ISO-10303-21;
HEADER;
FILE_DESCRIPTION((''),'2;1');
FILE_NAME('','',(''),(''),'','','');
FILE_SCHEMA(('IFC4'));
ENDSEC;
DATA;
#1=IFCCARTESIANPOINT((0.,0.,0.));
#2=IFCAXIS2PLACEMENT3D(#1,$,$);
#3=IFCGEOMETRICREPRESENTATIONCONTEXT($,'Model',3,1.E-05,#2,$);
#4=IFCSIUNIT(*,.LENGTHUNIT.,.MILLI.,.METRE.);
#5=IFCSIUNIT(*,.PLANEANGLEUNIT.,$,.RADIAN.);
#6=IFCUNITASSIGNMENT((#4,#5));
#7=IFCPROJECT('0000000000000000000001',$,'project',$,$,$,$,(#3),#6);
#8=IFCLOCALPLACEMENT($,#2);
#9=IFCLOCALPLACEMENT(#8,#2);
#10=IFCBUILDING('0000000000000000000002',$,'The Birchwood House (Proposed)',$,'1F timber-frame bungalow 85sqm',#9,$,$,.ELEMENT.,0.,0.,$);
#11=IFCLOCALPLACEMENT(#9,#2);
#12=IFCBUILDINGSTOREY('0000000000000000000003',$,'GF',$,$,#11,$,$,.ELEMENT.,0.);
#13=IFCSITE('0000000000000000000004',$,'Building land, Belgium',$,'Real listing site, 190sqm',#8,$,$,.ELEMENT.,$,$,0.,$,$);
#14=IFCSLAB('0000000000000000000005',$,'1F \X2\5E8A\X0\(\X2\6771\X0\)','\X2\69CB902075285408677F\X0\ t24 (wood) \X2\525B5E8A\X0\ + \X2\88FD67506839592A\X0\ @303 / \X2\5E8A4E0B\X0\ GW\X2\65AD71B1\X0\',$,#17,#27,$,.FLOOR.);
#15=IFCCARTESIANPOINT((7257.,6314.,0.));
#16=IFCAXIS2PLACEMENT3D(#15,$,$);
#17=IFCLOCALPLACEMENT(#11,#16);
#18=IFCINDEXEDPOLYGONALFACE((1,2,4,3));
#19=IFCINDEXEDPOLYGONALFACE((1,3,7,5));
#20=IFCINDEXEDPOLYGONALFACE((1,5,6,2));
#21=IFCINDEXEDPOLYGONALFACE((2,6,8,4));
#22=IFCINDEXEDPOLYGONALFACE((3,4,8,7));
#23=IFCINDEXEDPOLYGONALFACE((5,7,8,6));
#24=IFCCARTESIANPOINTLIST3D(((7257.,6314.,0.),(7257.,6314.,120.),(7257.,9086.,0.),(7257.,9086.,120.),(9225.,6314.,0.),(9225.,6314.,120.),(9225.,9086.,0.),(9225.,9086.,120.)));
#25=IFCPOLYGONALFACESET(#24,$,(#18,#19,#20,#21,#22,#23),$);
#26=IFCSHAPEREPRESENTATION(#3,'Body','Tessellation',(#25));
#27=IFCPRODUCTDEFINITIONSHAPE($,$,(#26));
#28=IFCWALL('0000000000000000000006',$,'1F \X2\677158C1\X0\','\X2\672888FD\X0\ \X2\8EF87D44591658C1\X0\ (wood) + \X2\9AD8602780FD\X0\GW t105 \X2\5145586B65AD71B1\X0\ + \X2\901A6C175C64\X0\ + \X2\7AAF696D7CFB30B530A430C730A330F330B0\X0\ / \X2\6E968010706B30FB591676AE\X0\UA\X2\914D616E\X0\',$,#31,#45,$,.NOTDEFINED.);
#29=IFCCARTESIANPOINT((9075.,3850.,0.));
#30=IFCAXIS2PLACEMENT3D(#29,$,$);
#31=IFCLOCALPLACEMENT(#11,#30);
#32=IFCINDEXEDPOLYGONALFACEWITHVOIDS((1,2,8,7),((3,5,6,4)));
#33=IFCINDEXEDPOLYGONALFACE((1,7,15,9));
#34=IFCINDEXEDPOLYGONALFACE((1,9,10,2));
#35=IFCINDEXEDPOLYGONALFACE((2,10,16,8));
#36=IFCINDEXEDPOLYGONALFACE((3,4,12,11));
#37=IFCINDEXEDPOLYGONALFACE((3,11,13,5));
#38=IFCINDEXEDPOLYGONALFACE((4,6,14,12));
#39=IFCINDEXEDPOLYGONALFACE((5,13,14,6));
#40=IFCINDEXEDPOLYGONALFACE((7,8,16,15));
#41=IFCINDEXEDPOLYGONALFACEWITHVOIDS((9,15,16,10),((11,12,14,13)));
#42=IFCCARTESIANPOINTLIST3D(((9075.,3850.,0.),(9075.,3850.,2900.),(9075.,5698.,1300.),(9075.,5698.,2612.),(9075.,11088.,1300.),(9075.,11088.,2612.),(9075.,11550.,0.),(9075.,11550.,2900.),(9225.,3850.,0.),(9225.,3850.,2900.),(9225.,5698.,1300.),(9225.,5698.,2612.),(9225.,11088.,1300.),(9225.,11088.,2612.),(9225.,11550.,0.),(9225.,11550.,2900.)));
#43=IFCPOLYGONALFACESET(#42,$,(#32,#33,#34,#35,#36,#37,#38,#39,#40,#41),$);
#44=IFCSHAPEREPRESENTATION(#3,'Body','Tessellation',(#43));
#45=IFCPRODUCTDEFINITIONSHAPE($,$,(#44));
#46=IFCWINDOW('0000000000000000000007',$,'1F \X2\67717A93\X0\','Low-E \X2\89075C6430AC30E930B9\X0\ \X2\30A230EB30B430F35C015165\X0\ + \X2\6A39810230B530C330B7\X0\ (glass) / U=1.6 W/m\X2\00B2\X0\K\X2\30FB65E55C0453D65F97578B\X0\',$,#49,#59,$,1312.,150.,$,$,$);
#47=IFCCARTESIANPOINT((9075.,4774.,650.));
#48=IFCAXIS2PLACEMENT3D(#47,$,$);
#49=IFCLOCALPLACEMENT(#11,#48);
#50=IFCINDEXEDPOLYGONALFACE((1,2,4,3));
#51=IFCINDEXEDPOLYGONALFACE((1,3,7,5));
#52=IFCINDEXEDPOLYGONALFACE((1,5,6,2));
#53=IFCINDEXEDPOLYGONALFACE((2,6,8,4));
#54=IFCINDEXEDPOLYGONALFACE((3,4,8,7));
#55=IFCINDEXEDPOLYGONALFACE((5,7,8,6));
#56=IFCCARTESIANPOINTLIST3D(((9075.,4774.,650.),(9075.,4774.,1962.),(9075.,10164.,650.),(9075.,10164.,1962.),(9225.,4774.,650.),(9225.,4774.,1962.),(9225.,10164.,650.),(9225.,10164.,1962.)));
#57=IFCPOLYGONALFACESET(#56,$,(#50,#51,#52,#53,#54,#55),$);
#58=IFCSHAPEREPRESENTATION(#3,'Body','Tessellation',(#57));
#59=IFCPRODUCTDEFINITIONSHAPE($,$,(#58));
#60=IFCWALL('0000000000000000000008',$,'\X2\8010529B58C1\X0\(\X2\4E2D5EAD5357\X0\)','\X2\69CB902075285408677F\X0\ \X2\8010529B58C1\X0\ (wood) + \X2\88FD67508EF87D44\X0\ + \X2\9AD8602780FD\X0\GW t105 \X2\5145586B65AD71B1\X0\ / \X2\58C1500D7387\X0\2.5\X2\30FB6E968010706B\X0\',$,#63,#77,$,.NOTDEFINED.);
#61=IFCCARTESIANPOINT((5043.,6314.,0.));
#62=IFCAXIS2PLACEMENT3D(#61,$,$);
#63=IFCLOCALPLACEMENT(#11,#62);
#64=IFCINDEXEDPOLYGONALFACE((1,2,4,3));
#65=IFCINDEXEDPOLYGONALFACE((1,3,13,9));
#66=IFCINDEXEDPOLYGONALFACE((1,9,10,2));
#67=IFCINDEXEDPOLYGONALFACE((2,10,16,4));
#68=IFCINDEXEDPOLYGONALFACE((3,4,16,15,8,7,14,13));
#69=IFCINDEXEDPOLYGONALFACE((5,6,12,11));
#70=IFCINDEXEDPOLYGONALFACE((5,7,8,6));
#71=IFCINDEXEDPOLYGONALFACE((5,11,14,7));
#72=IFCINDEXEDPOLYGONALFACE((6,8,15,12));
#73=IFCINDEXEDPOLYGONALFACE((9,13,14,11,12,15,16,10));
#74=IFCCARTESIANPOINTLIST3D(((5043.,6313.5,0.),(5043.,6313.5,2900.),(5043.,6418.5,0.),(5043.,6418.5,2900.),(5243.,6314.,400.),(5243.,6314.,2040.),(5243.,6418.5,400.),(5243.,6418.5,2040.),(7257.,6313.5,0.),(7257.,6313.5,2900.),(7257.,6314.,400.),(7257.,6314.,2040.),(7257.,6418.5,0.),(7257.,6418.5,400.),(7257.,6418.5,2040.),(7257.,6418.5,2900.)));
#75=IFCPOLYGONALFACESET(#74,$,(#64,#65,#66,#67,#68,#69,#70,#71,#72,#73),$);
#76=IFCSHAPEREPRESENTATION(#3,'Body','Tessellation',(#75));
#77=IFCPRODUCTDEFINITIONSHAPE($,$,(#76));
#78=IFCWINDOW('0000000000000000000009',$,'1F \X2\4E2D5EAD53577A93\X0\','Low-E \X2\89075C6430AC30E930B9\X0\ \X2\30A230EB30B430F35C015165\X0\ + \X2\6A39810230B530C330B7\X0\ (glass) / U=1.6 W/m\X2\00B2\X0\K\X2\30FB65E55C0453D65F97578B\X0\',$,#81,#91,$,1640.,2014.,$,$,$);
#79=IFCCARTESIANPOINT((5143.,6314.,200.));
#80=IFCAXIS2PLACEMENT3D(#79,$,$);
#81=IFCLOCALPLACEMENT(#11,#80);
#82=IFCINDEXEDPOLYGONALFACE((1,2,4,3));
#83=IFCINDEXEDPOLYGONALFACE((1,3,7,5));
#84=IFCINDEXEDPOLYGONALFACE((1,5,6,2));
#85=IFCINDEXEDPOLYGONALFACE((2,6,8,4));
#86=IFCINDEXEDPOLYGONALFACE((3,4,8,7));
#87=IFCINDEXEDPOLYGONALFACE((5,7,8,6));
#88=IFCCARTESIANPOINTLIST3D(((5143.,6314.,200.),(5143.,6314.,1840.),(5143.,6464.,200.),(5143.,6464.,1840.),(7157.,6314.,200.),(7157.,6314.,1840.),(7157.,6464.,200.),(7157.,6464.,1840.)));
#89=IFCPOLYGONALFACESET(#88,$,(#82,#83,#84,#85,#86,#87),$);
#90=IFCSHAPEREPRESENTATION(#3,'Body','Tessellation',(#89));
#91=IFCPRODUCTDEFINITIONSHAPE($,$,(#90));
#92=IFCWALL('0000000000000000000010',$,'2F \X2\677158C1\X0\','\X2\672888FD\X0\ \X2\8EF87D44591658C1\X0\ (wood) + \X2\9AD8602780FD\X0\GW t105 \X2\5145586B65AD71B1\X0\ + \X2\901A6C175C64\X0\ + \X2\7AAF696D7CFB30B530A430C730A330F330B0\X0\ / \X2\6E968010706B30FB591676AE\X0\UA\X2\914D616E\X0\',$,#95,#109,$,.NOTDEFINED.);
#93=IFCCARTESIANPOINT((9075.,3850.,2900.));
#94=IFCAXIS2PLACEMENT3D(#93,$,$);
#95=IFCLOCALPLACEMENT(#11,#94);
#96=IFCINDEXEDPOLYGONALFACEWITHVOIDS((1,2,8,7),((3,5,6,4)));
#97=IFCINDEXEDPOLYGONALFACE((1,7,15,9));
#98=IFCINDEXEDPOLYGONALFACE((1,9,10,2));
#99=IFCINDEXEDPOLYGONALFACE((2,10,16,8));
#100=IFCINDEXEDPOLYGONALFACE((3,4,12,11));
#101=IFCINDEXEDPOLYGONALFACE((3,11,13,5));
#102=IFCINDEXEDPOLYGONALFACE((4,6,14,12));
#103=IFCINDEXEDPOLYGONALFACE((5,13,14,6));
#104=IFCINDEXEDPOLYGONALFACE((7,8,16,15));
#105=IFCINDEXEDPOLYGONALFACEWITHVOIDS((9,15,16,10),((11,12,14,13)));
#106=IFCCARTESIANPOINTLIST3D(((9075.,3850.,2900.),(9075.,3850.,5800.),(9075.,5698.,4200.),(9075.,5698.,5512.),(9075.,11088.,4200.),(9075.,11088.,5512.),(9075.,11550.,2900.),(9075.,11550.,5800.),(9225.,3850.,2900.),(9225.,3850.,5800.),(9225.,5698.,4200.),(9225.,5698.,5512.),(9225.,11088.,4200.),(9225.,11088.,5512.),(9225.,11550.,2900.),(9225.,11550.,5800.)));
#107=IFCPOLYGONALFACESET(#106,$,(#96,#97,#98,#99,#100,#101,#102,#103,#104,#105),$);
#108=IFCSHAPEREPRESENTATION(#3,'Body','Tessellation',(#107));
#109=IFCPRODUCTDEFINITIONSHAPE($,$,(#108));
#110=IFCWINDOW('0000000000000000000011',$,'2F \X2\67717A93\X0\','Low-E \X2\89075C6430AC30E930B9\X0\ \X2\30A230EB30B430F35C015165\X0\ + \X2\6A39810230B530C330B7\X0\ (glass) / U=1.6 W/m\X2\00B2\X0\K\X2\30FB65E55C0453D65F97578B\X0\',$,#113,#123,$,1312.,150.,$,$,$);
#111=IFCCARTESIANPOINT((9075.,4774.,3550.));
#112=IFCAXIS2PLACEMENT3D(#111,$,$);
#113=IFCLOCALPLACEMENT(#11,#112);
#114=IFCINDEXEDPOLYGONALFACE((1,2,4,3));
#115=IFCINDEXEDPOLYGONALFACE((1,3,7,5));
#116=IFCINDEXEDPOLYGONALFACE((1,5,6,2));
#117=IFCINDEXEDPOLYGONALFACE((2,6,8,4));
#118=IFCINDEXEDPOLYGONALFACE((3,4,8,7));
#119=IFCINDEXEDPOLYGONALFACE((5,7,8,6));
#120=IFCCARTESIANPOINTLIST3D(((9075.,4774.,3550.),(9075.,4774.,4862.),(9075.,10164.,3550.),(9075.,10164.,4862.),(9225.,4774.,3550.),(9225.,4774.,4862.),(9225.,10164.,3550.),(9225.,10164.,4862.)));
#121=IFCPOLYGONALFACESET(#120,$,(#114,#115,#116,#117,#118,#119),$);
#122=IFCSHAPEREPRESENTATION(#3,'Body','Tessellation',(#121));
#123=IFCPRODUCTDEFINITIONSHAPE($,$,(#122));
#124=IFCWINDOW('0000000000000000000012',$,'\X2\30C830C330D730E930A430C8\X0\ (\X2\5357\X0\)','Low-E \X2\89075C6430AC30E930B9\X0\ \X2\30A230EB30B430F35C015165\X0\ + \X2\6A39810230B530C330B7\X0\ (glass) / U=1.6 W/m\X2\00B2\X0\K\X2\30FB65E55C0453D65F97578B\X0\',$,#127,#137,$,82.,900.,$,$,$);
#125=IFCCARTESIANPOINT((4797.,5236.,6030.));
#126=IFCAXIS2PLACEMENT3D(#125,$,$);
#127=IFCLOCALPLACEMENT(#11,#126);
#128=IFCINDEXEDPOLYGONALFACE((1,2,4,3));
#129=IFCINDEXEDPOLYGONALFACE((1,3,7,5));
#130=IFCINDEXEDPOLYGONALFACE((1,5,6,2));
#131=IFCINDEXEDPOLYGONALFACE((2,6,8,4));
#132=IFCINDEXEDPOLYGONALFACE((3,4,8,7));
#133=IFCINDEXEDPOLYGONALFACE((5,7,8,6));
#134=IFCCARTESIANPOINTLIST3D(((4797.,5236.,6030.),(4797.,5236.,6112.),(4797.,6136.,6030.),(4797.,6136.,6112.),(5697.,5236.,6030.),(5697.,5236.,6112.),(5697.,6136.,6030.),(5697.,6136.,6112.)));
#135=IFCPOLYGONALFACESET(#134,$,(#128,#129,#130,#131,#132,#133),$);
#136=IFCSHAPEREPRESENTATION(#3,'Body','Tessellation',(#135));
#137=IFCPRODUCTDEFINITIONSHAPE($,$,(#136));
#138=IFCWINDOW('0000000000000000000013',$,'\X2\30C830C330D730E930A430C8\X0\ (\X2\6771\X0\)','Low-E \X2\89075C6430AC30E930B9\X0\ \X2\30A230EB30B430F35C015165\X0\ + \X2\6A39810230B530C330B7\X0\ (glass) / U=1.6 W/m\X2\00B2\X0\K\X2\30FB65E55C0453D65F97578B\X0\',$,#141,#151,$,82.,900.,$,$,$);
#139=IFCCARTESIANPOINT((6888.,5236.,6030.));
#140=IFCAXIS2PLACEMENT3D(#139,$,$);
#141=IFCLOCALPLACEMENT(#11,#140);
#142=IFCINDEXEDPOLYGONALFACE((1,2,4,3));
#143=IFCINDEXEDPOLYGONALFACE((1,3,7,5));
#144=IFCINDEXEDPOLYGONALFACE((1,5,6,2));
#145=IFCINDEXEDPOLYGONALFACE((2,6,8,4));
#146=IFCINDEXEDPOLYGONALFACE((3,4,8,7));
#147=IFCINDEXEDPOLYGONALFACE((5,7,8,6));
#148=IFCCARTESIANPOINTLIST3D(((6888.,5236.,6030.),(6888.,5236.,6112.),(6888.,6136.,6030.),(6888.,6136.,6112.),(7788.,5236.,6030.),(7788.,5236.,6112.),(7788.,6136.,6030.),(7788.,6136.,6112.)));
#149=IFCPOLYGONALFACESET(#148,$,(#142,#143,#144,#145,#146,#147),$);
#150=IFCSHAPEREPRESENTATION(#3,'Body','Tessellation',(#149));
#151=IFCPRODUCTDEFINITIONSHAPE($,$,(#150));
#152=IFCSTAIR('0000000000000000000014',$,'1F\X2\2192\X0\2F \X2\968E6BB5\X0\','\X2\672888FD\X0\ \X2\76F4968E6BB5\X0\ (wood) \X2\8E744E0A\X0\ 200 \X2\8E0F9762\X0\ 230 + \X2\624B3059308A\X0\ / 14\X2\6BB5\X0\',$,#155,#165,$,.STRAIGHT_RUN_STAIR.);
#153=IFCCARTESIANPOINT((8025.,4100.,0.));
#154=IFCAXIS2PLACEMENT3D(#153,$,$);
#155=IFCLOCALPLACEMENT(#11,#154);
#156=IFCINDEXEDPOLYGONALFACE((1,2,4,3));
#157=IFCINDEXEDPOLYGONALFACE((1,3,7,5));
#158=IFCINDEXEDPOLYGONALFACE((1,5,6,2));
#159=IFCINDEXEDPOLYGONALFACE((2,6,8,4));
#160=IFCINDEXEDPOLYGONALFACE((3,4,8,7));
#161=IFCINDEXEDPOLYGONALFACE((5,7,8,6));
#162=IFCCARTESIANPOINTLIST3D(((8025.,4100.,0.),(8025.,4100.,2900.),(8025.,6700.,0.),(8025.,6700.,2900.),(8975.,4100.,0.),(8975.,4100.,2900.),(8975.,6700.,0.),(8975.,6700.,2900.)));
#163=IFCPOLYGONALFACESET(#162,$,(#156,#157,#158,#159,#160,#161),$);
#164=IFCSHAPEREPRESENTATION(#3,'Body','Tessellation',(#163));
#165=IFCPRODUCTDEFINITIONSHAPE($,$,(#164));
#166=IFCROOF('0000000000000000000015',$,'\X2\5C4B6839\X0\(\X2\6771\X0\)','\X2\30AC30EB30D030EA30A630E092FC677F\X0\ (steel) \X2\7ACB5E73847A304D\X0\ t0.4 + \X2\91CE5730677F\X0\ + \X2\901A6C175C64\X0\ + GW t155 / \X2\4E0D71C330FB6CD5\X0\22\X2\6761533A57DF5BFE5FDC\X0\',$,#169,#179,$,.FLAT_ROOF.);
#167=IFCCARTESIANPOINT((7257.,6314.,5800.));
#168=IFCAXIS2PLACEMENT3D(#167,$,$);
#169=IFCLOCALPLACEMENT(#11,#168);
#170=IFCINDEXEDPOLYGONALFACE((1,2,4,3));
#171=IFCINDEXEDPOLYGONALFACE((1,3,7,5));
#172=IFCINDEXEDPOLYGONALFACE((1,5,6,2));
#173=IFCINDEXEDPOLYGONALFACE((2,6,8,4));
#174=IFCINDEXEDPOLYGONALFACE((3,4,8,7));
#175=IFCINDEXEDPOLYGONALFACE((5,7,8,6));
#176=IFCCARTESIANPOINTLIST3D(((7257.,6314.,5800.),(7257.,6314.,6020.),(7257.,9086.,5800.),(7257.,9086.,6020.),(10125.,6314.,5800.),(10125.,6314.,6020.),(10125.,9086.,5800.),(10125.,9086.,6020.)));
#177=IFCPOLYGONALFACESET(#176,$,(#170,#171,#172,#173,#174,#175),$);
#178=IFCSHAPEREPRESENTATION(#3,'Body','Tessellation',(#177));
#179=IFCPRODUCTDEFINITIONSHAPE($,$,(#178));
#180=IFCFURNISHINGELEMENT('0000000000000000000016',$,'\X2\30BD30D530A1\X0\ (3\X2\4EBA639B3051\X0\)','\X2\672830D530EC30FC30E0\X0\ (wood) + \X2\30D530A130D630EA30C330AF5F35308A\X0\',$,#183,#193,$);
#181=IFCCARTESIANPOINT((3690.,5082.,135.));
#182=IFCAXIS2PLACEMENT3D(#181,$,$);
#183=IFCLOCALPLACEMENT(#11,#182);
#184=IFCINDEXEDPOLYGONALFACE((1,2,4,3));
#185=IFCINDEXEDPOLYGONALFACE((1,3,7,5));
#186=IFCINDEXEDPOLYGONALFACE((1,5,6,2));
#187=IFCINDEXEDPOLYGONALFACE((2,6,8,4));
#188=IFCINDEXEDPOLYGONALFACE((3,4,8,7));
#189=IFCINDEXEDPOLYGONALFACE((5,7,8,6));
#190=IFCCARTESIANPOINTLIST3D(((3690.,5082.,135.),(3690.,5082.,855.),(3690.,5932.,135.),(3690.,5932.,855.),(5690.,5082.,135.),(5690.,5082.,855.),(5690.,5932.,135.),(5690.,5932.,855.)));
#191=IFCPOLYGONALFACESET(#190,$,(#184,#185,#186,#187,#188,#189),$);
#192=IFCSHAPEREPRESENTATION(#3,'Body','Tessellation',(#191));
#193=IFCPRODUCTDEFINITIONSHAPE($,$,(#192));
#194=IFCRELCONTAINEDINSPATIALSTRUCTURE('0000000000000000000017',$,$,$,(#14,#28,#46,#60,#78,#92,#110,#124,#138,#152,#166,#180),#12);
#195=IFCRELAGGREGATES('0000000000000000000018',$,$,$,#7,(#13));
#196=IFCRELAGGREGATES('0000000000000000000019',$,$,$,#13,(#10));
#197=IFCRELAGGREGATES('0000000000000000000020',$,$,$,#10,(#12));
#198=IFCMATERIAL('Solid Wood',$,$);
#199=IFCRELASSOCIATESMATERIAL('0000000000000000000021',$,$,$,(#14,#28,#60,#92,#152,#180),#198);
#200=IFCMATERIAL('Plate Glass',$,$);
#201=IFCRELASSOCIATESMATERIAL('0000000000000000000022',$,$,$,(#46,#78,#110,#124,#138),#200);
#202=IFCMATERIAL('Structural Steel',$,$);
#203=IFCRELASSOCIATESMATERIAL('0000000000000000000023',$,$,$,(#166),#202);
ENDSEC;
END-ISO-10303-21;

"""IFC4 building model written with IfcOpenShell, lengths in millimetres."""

from ifc_helpers import new_model, si_unit, frame, frame_2d, origin, place, context, project, spatial, rectangle, extrude, material, element, fill, save


model = new_model("IFC4")

# Units and contexts
model_context = context("Model", 3, precision=1e-05, world=origin())
ifc_project = project(units=[si_unit("LENGTHUNIT", "METRE", prefix="MILLI"), si_unit("PLANEANGLEUNIT", "RADIAN")], contexts=[model_context])

# Site, building, storey
site_placement = place(None, origin())
site = spatial("IfcSite", under=ifc_project, at=site_placement, Name="Building land, Belgium", ObjectType="Real listing site, 190sqm", CompositionType="ELEMENT", RefElevation=0.0)
building_placement = place(site_placement, origin())
building = spatial("IfcBuilding", under=site, at=building_placement, Name="The Birchwood House (Proposed)", ObjectType="1F timber-frame bungalow 85sqm", CompositionType="ELEMENT", ElevationOfRefHeight=0.0, ElevationOfTerrain=0.0)
storey_placement = place(building_placement, origin())
storey = spatial("IfcBuildingStorey", under=building, at=storey_placement, Name="GF", CompositionType="ELEMENT", Elevation=0.0)

# Slab
ifc_material_1 = material(Name="Solid Wood")
slab_placement = place(storey_placement, frame((7257.0, 6314.0, 0.0)))
element("IfcSlab", 1, at=slab_placement, inside=storey, material=ifc_material_1, Name="1F 床(東)", Description="構造用合板 t24 (wood) 剛床 + 製材根太 @303 / 床下 GW断熱", PredefinedType="FLOOR", context=model_context, shape_type="SweptSolid", body=[
    extrude(rectangle(XDim=1968.0, YDim=2772.0, at=frame_2d((984.0, 1386.0))), frame((7257.0, 6314.0, 0.0)), (0.0, 0.0, 1.0), 120.0),
])

# Walls, openings, windows
wall_1_placement = place(storey_placement, frame((9075.0, 3850.0, 0.0)))
wall_1 = element("IfcWall", 2, at=wall_1_placement, inside=storey, material=ifc_material_1, Name="1F 東壁", Description="木製 軸組外壁 (wood) + 高性能GW t105 充填断熱 + 通気層 + 窯業系サイディング / 準耐火・外皮UA配慮", PredefinedType="NOTDEFINED", context=model_context, shape_type="SweptSolid", body=[
    extrude(rectangle(XDim=150.0, YDim=7700.0, at=frame_2d((75.0, 3850.0))), frame((9075.0, 3850.0, 0.0)), (0.0, 0.0, 1.0), 2900.0),
])
opening_1_placement = place(storey_placement, frame((9075.0, 4774.0, 650.0)))
opening_1 = element("IfcOpeningElement", 3, at=opening_1_placement, cuts=wall_1, PredefinedType="NOTDEFINED", context=model_context, shape_type="SweptSolid", body=[
    extrude(rectangle(XDim=150.0, YDim=5390.0, at=frame_2d((75.0, 2695.0))), frame((9075.0, 4774.0, 650.0)), (0.0, 0.0, 1.0), 1312.0),
])
ifc_material_2 = material(Name="Plate Glass")
window_1_placement = place(storey_placement, frame((9075.0, 4774.0, 650.0)))
window_1 = element("IfcWindow", 4, at=window_1_placement, inside=storey, material=ifc_material_2, Name="1F 東窓", Description="Low-E 複層ガラス アルゴン封入 + 樹脂サッシ (glass) / U=1.6 W/m²K・日射取得型", OverallHeight=1312.0, OverallWidth=150.0, context=model_context, shape_type="SweptSolid", body=[
    extrude(rectangle(XDim=150.0, YDim=5390.0, at=frame_2d((75.0, 2695.0))), frame((9075.0, 4774.0, 650.0)), (0.0, 0.0, 1.0), 1312.0),
])
fill(opening_1, window_1)
wall_2_placement = place(storey_placement, frame((5043.0, 6314.0, 0.0)))
wall_2 = element("IfcWall", 5, at=wall_2_placement, inside=storey, material=ifc_material_1, Name="耐力壁(中庭南)", Description="構造用合板 耐力壁 (wood) + 製材軸組 + 高性能GW t105 充填断熱 / 壁倍率2.5・準耐火", PredefinedType="NOTDEFINED", context=model_context, shape_type="SweptSolid", body=[
    extrude(rectangle(XDim=2214.0, YDim=105.0, at=frame_2d((1107.0, 52.0))), frame((5043.0, 6314.0, 0.0)), (0.0, 0.0, 1.0), 2900.0),
])
opening_2_placement = place(storey_placement, frame((5143.0, 6314.0, 200.0)))
opening_2 = element("IfcOpeningElement", 6, at=opening_2_placement, cuts=wall_2, PredefinedType="NOTDEFINED", context=model_context, shape_type="SweptSolid", body=[
    extrude(rectangle(XDim=2014.0, YDim=150.0, at=frame_2d((1007.0, 75.0))), frame((5143.0, 6314.0, 200.0)), (0.0, 0.0, 1.0), 1640.0),
])
window_2_placement = place(storey_placement, frame((5143.0, 6314.0, 200.0)))
window_2 = element("IfcWindow", 7, at=window_2_placement, inside=storey, material=ifc_material_2, Name="1F 中庭南窓", Description="Low-E 複層ガラス アルゴン封入 + 樹脂サッシ (glass) / U=1.6 W/m²K・日射取得型", OverallHeight=1640.0, OverallWidth=2014.0, context=model_context, shape_type="SweptSolid", body=[
    extrude(rectangle(XDim=2014.0, YDim=150.0, at=frame_2d((1007.0, 75.0))), frame((5143.0, 6314.0, 200.0)), (0.0, 0.0, 1.0), 1640.0),
])
fill(opening_2, window_2)

# Wall, opening, window
wall_3_placement = place(storey_placement, frame((9075.0, 3850.0, 2900.0)))
wall_3 = element("IfcWall", 8, at=wall_3_placement, inside=storey, material=ifc_material_1, Name="2F 東壁", Description="木製 軸組外壁 (wood) + 高性能GW t105 充填断熱 + 通気層 + 窯業系サイディング / 準耐火・外皮UA配慮", PredefinedType="NOTDEFINED", context=model_context, shape_type="SweptSolid", body=[
    extrude(rectangle(XDim=150.0, YDim=7700.0, at=frame_2d((75.0, 3850.0))), frame((9075.0, 3850.0, 2900.0)), (0.0, 0.0, 1.0), 2900.0),
])
opening_3_placement = place(storey_placement, frame((9075.0, 4774.0, 3550.0)))
opening_3 = element("IfcOpeningElement", 9, at=opening_3_placement, cuts=wall_3, PredefinedType="NOTDEFINED", context=model_context, shape_type="SweptSolid", body=[
    extrude(rectangle(XDim=150.0, YDim=5390.0, at=frame_2d((75.0, 2695.0))), frame((9075.0, 4774.0, 3550.0)), (0.0, 0.0, 1.0), 1312.0),
])
window_3_placement = place(storey_placement, frame((9075.0, 4774.0, 3550.0)))
window_3 = element("IfcWindow", 10, at=window_3_placement, inside=storey, material=ifc_material_2, Name="2F 東窓", Description="Low-E 複層ガラス アルゴン封入 + 樹脂サッシ (glass) / U=1.6 W/m²K・日射取得型", OverallHeight=1312.0, OverallWidth=150.0, context=model_context, shape_type="SweptSolid", body=[
    extrude(rectangle(XDim=150.0, YDim=5390.0, at=frame_2d((75.0, 2695.0))), frame((9075.0, 4774.0, 3550.0)), (0.0, 0.0, 1.0), 1312.0),
])
fill(opening_3, window_3)

# Windows
window_4_placement = place(storey_placement, frame((4797.0, 5236.0, 6030.0)))
element("IfcWindow", 11, at=window_4_placement, inside=storey, material=ifc_material_2, Name="トップライト (南)", Description="Low-E 複層ガラス アルゴン封入 + 樹脂サッシ (glass) / U=1.6 W/m²K・日射取得型", OverallHeight=82.0, OverallWidth=900.0, context=model_context, shape_type="SweptSolid", body=[
    extrude(rectangle(XDim=900.0, YDim=900.0, at=frame_2d((450.0, 450.0))), frame((4797.0, 5236.0, 6030.0)), (0.0, 0.0, 1.0), 82.0),
])
window_5_placement = place(storey_placement, frame((6888.0, 5236.0, 6030.0)))
element("IfcWindow", 12, at=window_5_placement, inside=storey, material=ifc_material_2, Name="トップライト (東)", Description="Low-E 複層ガラス アルゴン封入 + 樹脂サッシ (glass) / U=1.6 W/m²K・日射取得型", OverallHeight=82.0, OverallWidth=900.0, context=model_context, shape_type="SweptSolid", body=[
    extrude(rectangle(XDim=900.0, YDim=900.0, at=frame_2d((450.0, 450.0))), frame((6888.0, 5236.0, 6030.0)), (0.0, 0.0, 1.0), 82.0),
])

# Stair
stair_placement = place(storey_placement, frame((8025.0, 4100.0, 0.0)))
element("IfcStair", 13, at=stair_placement, inside=storey, material=ifc_material_1, Name="1F→2F 階段", Description="木製 直階段 (wood) 蹴上 200 踏面 230 + 手すり / 14段", PredefinedType="STRAIGHT_RUN_STAIR", context=model_context, shape_type="SweptSolid", body=[
    extrude(rectangle(XDim=950.0, YDim=2600.0, at=frame_2d((475.0, 1300.0))), frame((8025.0, 4100.0, 0.0)), (0.0, 0.0, 1.0), 2900.0),
])

# Roof
ifc_material_3 = material(Name="Structural Steel")
roof_placement = place(storey_placement, frame((7257.0, 6314.0, 5800.0)))
element("IfcRoof", 14, at=roof_placement, inside=storey, material=ifc_material_3, Name="屋根(東)", Description="ガルバリウム鋼板 (steel) 立平葺き t0.4 + 野地板 + 通気層 + GW t155 / 不燃・法22条区域対応", PredefinedType="FLAT_ROOF", context=model_context, shape_type="SweptSolid", body=[
    extrude(rectangle(XDim=2868.0, YDim=2772.0, at=frame_2d((1434.0, 1386.0))), frame((7257.0, 6314.0, 5800.0)), (0.0, 0.0, 1.0), 220.0),
])

# Furnishing element
furnishing_1_placement = place(storey_placement, frame((3690.0, 5082.0, 135.0)))
element("IfcFurnishingElement", 15, at=furnishing_1_placement, inside=storey, material=ifc_material_1, Name="ソファ (3人掛け)", Description="木フレーム (wood) + ファブリック張り", context=model_context, shape_type="SweptSolid", body=[
    extrude(rectangle(XDim=2000.0, YDim=850.0, at=frame_2d((1000.0, 425.0))), frame((3690.0, 5082.0, 135.0)), (0.0, 0.0, 1.0), 720.0),
])

save(model, "model.ifc")
